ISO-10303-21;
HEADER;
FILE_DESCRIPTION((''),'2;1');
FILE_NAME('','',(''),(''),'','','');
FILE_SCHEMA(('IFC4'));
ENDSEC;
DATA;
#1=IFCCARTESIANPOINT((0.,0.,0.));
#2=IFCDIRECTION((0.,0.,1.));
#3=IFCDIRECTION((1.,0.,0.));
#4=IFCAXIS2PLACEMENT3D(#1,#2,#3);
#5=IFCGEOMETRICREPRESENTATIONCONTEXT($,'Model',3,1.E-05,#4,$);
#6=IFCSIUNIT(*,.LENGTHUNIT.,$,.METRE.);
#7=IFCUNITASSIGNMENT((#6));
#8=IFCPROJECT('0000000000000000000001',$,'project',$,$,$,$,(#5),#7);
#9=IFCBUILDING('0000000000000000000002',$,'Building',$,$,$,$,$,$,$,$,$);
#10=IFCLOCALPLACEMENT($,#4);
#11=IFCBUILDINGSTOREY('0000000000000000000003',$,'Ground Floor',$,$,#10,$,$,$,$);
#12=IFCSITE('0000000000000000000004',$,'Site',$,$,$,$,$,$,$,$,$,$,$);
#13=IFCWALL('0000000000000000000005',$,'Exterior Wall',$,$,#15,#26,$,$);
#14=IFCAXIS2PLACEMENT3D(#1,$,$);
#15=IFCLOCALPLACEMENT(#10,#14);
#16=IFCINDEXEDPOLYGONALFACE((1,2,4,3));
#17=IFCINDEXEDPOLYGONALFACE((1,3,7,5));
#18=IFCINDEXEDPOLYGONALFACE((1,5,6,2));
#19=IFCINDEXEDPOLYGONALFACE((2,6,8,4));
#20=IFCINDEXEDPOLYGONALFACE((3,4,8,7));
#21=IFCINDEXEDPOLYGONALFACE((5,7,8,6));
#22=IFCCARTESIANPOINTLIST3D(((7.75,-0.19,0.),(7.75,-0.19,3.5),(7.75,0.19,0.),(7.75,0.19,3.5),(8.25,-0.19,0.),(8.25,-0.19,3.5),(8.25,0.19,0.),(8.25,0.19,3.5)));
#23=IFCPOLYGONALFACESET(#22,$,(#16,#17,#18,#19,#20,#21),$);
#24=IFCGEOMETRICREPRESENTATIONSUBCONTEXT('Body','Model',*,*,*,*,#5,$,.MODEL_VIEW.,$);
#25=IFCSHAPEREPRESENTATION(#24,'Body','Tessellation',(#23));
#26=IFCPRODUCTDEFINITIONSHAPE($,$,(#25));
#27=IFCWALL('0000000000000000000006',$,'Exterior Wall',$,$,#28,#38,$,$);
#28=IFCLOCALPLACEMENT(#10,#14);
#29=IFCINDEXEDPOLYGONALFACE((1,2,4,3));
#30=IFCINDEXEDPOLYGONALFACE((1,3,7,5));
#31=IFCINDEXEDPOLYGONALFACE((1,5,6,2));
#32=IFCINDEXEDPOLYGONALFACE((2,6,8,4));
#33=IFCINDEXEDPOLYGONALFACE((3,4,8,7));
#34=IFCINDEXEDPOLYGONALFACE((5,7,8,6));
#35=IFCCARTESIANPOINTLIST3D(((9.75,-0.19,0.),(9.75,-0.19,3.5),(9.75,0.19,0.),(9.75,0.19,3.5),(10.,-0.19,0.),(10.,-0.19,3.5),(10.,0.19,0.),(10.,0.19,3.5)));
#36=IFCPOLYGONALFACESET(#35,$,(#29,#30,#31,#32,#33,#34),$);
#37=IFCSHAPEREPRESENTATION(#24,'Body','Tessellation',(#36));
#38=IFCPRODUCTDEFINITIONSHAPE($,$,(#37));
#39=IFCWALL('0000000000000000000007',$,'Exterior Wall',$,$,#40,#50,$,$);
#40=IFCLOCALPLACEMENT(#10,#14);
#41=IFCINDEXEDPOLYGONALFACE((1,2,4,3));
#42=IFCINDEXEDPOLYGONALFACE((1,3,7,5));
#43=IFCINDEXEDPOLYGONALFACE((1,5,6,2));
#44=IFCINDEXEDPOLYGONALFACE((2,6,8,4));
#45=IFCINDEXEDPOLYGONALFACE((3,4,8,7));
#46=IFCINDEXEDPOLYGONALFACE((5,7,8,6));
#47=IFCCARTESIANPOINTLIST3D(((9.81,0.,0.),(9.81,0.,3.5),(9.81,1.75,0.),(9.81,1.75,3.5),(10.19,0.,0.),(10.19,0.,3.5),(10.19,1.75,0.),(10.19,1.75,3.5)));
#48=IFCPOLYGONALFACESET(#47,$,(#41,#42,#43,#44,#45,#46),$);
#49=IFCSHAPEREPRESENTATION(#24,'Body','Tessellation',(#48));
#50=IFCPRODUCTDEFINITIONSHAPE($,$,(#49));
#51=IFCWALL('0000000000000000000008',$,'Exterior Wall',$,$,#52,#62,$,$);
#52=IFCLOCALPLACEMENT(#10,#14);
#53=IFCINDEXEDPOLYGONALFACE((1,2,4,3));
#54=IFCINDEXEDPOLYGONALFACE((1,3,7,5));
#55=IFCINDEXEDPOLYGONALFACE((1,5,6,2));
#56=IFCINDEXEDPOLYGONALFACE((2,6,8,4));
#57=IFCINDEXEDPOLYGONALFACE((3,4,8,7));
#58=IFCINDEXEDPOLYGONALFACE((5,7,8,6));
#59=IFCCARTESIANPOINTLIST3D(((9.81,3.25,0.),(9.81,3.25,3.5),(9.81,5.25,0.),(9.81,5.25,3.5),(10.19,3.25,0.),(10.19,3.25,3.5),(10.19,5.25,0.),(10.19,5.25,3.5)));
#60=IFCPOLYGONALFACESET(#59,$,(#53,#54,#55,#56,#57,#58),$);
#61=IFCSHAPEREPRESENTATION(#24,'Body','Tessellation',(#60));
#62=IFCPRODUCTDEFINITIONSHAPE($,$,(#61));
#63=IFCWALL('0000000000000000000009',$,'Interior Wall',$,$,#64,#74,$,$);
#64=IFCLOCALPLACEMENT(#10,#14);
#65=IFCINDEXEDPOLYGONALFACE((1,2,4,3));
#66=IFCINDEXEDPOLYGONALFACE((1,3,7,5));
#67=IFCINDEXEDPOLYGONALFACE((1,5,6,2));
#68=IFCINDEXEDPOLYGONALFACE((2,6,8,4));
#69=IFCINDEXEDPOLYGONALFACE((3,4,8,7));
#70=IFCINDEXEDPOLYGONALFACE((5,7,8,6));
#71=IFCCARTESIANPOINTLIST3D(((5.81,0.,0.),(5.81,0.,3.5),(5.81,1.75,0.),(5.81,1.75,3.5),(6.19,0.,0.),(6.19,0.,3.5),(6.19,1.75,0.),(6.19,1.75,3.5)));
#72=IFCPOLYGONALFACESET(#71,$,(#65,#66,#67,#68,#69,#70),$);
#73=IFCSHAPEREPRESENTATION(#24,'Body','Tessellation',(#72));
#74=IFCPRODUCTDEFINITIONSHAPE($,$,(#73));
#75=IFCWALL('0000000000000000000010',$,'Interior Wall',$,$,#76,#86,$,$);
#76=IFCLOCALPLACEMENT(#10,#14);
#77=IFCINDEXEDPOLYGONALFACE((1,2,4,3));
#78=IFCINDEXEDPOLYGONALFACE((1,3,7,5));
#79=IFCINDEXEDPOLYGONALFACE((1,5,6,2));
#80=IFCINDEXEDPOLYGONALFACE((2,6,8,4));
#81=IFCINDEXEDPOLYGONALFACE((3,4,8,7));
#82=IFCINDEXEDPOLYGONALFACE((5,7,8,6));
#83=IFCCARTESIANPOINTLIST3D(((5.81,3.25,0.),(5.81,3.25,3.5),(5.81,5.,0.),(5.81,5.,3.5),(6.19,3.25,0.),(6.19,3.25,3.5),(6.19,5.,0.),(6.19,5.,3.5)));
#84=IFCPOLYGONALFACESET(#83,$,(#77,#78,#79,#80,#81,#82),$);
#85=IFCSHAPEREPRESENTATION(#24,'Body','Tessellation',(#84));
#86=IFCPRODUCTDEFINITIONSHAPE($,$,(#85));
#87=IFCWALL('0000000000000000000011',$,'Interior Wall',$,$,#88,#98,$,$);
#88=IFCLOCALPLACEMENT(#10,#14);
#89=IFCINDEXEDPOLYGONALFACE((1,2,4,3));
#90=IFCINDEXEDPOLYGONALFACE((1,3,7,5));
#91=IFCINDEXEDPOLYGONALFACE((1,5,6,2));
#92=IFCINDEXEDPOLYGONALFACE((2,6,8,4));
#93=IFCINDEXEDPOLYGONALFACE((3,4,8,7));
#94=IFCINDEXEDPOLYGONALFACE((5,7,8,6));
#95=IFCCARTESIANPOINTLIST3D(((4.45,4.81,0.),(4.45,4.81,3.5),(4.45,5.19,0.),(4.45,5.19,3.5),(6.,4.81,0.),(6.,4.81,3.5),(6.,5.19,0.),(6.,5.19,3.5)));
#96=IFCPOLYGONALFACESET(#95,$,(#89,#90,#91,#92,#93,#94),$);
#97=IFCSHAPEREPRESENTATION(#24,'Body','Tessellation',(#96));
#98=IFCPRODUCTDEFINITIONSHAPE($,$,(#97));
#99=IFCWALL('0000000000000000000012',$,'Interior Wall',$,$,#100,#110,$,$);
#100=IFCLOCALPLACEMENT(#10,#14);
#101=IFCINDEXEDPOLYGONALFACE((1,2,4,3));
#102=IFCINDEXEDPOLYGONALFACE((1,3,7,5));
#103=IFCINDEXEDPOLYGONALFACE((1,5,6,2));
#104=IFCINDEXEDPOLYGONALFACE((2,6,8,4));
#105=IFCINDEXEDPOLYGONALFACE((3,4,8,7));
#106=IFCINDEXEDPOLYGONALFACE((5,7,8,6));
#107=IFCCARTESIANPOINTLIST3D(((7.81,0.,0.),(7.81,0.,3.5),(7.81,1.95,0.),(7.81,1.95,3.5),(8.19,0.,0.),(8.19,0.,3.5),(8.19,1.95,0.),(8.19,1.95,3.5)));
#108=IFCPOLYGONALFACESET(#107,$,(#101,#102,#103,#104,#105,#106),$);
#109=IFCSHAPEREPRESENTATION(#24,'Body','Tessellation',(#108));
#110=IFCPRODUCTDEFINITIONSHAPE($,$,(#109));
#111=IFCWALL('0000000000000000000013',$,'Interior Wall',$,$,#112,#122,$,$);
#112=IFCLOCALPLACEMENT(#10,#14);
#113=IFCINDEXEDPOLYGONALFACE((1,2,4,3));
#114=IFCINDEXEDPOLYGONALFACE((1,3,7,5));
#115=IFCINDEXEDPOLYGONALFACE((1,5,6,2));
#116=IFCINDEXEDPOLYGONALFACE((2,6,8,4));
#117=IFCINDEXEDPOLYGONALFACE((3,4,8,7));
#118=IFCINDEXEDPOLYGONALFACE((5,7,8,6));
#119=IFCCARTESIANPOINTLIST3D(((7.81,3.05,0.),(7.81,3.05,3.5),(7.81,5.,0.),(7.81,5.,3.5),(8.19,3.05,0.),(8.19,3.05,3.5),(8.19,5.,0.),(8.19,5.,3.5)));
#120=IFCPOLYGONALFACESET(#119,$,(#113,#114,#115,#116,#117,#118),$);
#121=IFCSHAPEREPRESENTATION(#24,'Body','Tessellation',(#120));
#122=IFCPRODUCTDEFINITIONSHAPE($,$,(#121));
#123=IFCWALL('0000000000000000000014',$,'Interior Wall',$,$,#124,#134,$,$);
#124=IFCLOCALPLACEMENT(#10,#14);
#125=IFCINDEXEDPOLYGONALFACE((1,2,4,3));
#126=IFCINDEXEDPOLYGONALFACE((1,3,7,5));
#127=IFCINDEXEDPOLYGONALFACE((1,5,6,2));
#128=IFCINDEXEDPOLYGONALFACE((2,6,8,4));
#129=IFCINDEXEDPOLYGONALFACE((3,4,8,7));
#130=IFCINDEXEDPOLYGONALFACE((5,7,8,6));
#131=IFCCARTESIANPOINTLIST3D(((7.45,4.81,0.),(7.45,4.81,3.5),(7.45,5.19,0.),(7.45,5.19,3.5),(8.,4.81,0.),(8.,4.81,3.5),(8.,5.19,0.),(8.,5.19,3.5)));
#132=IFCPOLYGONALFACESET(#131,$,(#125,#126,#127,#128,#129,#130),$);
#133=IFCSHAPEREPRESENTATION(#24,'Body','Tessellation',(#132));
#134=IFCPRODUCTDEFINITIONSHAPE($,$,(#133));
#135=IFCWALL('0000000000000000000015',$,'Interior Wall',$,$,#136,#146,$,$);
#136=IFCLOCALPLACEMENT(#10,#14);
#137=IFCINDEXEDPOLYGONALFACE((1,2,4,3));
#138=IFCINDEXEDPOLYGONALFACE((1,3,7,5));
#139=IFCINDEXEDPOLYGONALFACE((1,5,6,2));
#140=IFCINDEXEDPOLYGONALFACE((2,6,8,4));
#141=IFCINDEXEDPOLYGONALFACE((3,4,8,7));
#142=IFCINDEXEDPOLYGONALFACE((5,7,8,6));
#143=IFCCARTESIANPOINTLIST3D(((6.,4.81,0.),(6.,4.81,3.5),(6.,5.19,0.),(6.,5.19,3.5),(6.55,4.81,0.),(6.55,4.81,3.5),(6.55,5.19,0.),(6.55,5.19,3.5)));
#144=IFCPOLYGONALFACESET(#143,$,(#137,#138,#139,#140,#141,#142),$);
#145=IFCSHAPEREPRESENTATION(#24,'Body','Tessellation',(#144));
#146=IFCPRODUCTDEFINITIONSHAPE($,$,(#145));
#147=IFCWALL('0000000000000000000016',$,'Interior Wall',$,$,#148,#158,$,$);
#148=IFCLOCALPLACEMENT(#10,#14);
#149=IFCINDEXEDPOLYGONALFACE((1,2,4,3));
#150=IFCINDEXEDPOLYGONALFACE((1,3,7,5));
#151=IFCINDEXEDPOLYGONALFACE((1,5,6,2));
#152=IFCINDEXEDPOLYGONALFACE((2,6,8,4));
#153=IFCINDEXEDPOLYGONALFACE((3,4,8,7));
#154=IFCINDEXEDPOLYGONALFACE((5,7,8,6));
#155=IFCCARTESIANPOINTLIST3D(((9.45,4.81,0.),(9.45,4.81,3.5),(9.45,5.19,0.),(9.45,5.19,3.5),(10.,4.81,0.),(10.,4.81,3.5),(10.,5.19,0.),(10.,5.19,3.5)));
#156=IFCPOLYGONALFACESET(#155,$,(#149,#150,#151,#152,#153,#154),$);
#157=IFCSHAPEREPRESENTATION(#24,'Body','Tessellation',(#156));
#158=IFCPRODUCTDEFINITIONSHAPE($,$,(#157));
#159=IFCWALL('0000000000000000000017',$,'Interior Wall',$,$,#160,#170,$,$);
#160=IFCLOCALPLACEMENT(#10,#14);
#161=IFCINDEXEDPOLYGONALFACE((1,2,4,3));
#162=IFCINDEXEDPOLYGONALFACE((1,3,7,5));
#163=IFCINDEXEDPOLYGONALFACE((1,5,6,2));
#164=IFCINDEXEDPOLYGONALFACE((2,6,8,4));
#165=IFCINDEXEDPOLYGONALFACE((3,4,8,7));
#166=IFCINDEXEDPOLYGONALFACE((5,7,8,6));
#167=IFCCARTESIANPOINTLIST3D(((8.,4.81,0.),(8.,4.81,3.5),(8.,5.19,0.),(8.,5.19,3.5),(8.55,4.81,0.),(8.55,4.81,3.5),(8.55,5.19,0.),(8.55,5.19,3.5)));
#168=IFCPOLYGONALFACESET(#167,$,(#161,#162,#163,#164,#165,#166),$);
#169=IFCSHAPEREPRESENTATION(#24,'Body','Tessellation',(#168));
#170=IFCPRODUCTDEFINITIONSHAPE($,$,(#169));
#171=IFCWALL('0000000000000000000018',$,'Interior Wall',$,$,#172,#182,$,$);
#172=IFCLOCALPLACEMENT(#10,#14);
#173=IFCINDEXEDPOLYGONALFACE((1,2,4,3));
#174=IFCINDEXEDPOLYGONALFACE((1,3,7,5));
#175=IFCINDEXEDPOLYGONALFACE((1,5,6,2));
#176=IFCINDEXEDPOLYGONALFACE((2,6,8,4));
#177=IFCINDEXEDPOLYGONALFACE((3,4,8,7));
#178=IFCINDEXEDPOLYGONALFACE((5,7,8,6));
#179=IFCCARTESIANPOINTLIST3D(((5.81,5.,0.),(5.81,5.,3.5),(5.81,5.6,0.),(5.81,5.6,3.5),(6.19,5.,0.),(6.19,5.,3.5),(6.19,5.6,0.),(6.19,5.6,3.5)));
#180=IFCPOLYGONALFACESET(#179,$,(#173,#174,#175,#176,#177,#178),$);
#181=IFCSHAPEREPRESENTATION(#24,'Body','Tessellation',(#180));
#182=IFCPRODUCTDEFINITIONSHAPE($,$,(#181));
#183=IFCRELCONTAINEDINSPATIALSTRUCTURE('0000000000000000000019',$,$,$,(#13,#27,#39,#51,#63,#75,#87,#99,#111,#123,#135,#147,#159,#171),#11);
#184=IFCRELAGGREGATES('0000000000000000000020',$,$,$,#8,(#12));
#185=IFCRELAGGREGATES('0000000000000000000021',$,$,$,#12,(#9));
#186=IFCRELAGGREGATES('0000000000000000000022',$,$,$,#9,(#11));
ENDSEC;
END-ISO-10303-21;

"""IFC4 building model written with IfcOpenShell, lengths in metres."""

from ifc_helpers import new_model, si_unit, frame, origin_with_axes, place, context, subcontext, project, spatial, indexed_curve, outline, extrude, element, save


model = new_model("IFC4")

# Units and contexts
model_context = context("Model", 3, precision=1e-05, world=origin_with_axes())
body_context = subcontext(model_context, "Body", "Model", "MODEL_VIEW")
ifc_project = project(units=[si_unit("LENGTHUNIT", "METRE")], contexts=[model_context])

# Site, building, storey
site = spatial("IfcSite", under=ifc_project, Name="Site")
building = spatial("IfcBuilding", under=site, Name="Building")
storey_placement = place(None, origin_with_axes())
storey = spatial("IfcBuildingStorey", under=building, at=storey_placement, Name="Ground Floor")

# Walls
wall_1_placement = place(storey_placement, frame((7.75, 0.0, 0.0), z_axis=(0.0, 0.0, 1.0), x_axis=(1.0, 0.0, 0.0)))
element("IfcWall", 1, at=wall_1_placement, inside=storey, Name="Exterior Wall", context=body_context, shape_type="SweptSolid", body=[
    extrude(outline(indexed_curve([(0.0, 0.0), (0.0, 0.38), (0.5, 0.38), (0.5, 0.0), (0.0, 0.0)], self_intersect=False)), frame((0.0, -0.19, 0.0), z_axis=(0.0, 0.0, 1.0), x_axis=(1.0, 0.0, 0.0)), (0.0, 0.0, 1.0), 3.5),
])
wall_2_placement = place(storey_placement, frame((9.75, 0.0, 0.0), z_axis=(0.0, 0.0, 1.0), x_axis=(1.0, 0.0, 0.0)))
element("IfcWall", 2, at=wall_2_placement, inside=storey, Name="Exterior Wall", context=body_context, shape_type="SweptSolid", body=[
    extrude(outline(indexed_curve([(0.0, 0.0), (0.0, 0.38), (0.25, 0.38), (0.25, 0.0), (0.0, 0.0)], self_intersect=False)), frame((0.0, -0.19, 0.0), z_axis=(0.0, 0.0, 1.0), x_axis=(1.0, 0.0, 0.0)), (0.0, 0.0, 1.0), 3.5),
])
wall_3_placement = place(storey_placement, frame((10.0, 0.0, 0.0), z_axis=(0.0, 0.0, 1.0), x_axis=(0.0, 1.0, 0.0)))
element("IfcWall", 3, at=wall_3_placement, inside=storey, Name="Exterior Wall", context=body_context, shape_type="SweptSolid", body=[
    extrude(outline(indexed_curve([(0.0, 0.0), (0.0, 0.38), (1.75, 0.38), (1.75, 0.0), (0.0, 0.0)], self_intersect=False)), frame((0.0, -0.19, 0.0), z_axis=(0.0, 0.0, 1.0), x_axis=(1.0, 0.0, 0.0)), (0.0, 0.0, 1.0), 3.5),
])
wall_4_placement = place(storey_placement, frame((10.0, 3.25, 0.0), z_axis=(0.0, 0.0, 1.0), x_axis=(0.0, 1.0, 0.0)))
element("IfcWall", 4, at=wall_4_placement, inside=storey, Name="Exterior Wall", context=body_context, shape_type="SweptSolid", body=[
    extrude(outline(indexed_curve([(0.0, 0.0), (0.0, 0.38), (2.0, 0.38), (2.0, 0.0), (0.0, 0.0)], self_intersect=False)), frame((0.0, -0.19, 0.0), z_axis=(0.0, 0.0, 1.0), x_axis=(1.0, 0.0, 0.0)), (0.0, 0.0, 1.0), 3.5),
])
for number, where, z_axis, x_axis, name in (
    (5, (6.0, 0.0, 0.0), (0.0, 0.0, 1.0), (0.0, 1.0, 0.0), "Interior Wall"),
    (6, (6.0, 3.25, 0.0), (0.0, 0.0, 1.0), (0.0, 1.0, 0.0), "Interior Wall"),
):
    element("IfcWall", number, at=place(storey_placement, frame(where, z_axis=z_axis, x_axis=x_axis)), inside=storey, Name=name, context=body_context, shape_type="SweptSolid", body=[
        extrude(outline(indexed_curve([(0.0, 0.0), (0.0, 0.38), (1.75, 0.38), (1.75, 0.0), (0.0, 0.0)], self_intersect=False)), frame((0.0, -0.19, 0.0), z_axis=(0.0, 0.0, 1.0), x_axis=(1.0, 0.0, 0.0)), (0.0, 0.0, 1.0), 3.5),
    ])
wall_5_placement = place(storey_placement, frame((6.0, 5.0, 0.0), z_axis=(0.0, 0.0, 1.0), x_axis=(-1.0, 0.0, 0.0)))
element("IfcWall", 7, at=wall_5_placement, inside=storey, Name="Interior Wall", context=body_context, shape_type="SweptSolid", body=[
    extrude(outline(indexed_curve([(0.0, 0.0), (0.0, 0.38), (1.55, 0.38), (1.55, 0.0), (0.0, 0.0)], self_intersect=False)), frame((0.0, -0.19, 0.0), z_axis=(0.0, 0.0, 1.0), x_axis=(1.0, 0.0, 0.0)), (0.0, 0.0, 1.0), 3.5),
])
wall_6_placement = place(storey_placement, frame((8.0, 0.0, 0.0), z_axis=(0.0, 0.0, 1.0), x_axis=(0.0, 1.0, 0.0)))
element("IfcWall", 8, at=wall_6_placement, inside=storey, Name="Interior Wall", context=body_context, shape_type="SweptSolid", body=[
    extrude(outline(indexed_curve([(0.0, 0.0), (0.0, 0.38), (1.95, 0.38), (1.95, 0.0), (0.0, 0.0)], self_intersect=False)), frame((0.0, -0.19, 0.0), z_axis=(0.0, 0.0, 1.0), x_axis=(1.0, 0.0, 0.0)), (0.0, 0.0, 1.0), 3.5),
])
wall_7_placement = place(storey_placement, frame((8.0, 3.05, 0.0), z_axis=(0.0, 0.0, 1.0), x_axis=(0.0, 1.0, 0.0)))
element("IfcWall", 9, at=wall_7_placement, inside=storey, Name="Interior Wall", context=body_context, shape_type="SweptSolid", body=[
    extrude(outline(indexed_curve([(0.0, 0.0), (0.0, 0.38), (1.95, 0.38), (1.95, 0.0), (0.0, 0.0)], self_intersect=False)), frame((0.0, -0.19, 0.0), z_axis=(0.0, 0.0, 1.0), x_axis=(1.0, 0.0, 0.0)), (0.0, 0.0, 1.0), 3.5),
])
for number, where, z_axis, x_axis, name in (
    (10, (8.0, 5.0, 0.0), (0.0, 0.0, 1.0), (-1.0, 0.0, 0.0), "Interior Wall"),
    (11, (6.55, 5.0, 0.0), (0.0, 0.0, 1.0), (-1.0, 0.0, 0.0), "Interior Wall"),
):
    element("IfcWall", number, at=place(storey_placement, frame(where, z_axis=z_axis, x_axis=x_axis)), inside=storey, Name=name, context=body_context, shape_type="SweptSolid", body=[
        extrude(outline(indexed_curve([(0.0, 0.0), (0.0, 0.38), (0.55, 0.38), (0.55, 0.0), (0.0, 0.0)], self_intersect=False)), frame((0.0, -0.19, 0.0), z_axis=(0.0, 0.0, 1.0), x_axis=(1.0, 0.0, 0.0)), (0.0, 0.0, 1.0), 3.5),
    ])
for number, where, z_axis, x_axis, name in (
    (12, (10.0, 5.0, 0.0), (0.0, 0.0, 1.0), (-1.0, 0.0, 0.0), "Interior Wall"),
    (13, (8.55, 5.0, 0.0), (0.0, 0.0, 1.0), (-1.0, 0.0, 0.0), "Interior Wall"),
):
    element("IfcWall", number, at=place(storey_placement, frame(where, z_axis=z_axis, x_axis=x_axis)), inside=storey, Name=name, context=body_context, shape_type="SweptSolid", body=[
        extrude(outline(indexed_curve([(0.0, 0.0), (0.0, 0.38), (0.55, 0.38), (0.55, 0.0), (0.0, 0.0)], self_intersect=False)), frame((0.0, -0.19, 0.0), z_axis=(0.0, 0.0, 1.0), x_axis=(1.0, 0.0, 0.0)), (0.0, 0.0, 1.0), 3.5),
    ])
wall_8_placement = place(storey_placement, frame((6.0, 5.0, 0.0), z_axis=(0.0, 0.0, 1.0), x_axis=(0.0, 1.0, 0.0)))
element("IfcWall", 14, at=wall_8_placement, inside=storey, Name="Interior Wall", context=body_context, shape_type="SweptSolid", body=[
    extrude(outline(indexed_curve([(0.0, 0.0), (0.0, 0.38), (0.6, 0.38), (0.6, 0.0), (0.0, 0.0)], self_intersect=False)), frame((0.0, -0.19, 0.0), z_axis=(0.0, 0.0, 1.0), x_axis=(1.0, 0.0, 0.0)), (0.0, 0.0, 1.0), 3.5),
])

save(model, "model.ifc")
